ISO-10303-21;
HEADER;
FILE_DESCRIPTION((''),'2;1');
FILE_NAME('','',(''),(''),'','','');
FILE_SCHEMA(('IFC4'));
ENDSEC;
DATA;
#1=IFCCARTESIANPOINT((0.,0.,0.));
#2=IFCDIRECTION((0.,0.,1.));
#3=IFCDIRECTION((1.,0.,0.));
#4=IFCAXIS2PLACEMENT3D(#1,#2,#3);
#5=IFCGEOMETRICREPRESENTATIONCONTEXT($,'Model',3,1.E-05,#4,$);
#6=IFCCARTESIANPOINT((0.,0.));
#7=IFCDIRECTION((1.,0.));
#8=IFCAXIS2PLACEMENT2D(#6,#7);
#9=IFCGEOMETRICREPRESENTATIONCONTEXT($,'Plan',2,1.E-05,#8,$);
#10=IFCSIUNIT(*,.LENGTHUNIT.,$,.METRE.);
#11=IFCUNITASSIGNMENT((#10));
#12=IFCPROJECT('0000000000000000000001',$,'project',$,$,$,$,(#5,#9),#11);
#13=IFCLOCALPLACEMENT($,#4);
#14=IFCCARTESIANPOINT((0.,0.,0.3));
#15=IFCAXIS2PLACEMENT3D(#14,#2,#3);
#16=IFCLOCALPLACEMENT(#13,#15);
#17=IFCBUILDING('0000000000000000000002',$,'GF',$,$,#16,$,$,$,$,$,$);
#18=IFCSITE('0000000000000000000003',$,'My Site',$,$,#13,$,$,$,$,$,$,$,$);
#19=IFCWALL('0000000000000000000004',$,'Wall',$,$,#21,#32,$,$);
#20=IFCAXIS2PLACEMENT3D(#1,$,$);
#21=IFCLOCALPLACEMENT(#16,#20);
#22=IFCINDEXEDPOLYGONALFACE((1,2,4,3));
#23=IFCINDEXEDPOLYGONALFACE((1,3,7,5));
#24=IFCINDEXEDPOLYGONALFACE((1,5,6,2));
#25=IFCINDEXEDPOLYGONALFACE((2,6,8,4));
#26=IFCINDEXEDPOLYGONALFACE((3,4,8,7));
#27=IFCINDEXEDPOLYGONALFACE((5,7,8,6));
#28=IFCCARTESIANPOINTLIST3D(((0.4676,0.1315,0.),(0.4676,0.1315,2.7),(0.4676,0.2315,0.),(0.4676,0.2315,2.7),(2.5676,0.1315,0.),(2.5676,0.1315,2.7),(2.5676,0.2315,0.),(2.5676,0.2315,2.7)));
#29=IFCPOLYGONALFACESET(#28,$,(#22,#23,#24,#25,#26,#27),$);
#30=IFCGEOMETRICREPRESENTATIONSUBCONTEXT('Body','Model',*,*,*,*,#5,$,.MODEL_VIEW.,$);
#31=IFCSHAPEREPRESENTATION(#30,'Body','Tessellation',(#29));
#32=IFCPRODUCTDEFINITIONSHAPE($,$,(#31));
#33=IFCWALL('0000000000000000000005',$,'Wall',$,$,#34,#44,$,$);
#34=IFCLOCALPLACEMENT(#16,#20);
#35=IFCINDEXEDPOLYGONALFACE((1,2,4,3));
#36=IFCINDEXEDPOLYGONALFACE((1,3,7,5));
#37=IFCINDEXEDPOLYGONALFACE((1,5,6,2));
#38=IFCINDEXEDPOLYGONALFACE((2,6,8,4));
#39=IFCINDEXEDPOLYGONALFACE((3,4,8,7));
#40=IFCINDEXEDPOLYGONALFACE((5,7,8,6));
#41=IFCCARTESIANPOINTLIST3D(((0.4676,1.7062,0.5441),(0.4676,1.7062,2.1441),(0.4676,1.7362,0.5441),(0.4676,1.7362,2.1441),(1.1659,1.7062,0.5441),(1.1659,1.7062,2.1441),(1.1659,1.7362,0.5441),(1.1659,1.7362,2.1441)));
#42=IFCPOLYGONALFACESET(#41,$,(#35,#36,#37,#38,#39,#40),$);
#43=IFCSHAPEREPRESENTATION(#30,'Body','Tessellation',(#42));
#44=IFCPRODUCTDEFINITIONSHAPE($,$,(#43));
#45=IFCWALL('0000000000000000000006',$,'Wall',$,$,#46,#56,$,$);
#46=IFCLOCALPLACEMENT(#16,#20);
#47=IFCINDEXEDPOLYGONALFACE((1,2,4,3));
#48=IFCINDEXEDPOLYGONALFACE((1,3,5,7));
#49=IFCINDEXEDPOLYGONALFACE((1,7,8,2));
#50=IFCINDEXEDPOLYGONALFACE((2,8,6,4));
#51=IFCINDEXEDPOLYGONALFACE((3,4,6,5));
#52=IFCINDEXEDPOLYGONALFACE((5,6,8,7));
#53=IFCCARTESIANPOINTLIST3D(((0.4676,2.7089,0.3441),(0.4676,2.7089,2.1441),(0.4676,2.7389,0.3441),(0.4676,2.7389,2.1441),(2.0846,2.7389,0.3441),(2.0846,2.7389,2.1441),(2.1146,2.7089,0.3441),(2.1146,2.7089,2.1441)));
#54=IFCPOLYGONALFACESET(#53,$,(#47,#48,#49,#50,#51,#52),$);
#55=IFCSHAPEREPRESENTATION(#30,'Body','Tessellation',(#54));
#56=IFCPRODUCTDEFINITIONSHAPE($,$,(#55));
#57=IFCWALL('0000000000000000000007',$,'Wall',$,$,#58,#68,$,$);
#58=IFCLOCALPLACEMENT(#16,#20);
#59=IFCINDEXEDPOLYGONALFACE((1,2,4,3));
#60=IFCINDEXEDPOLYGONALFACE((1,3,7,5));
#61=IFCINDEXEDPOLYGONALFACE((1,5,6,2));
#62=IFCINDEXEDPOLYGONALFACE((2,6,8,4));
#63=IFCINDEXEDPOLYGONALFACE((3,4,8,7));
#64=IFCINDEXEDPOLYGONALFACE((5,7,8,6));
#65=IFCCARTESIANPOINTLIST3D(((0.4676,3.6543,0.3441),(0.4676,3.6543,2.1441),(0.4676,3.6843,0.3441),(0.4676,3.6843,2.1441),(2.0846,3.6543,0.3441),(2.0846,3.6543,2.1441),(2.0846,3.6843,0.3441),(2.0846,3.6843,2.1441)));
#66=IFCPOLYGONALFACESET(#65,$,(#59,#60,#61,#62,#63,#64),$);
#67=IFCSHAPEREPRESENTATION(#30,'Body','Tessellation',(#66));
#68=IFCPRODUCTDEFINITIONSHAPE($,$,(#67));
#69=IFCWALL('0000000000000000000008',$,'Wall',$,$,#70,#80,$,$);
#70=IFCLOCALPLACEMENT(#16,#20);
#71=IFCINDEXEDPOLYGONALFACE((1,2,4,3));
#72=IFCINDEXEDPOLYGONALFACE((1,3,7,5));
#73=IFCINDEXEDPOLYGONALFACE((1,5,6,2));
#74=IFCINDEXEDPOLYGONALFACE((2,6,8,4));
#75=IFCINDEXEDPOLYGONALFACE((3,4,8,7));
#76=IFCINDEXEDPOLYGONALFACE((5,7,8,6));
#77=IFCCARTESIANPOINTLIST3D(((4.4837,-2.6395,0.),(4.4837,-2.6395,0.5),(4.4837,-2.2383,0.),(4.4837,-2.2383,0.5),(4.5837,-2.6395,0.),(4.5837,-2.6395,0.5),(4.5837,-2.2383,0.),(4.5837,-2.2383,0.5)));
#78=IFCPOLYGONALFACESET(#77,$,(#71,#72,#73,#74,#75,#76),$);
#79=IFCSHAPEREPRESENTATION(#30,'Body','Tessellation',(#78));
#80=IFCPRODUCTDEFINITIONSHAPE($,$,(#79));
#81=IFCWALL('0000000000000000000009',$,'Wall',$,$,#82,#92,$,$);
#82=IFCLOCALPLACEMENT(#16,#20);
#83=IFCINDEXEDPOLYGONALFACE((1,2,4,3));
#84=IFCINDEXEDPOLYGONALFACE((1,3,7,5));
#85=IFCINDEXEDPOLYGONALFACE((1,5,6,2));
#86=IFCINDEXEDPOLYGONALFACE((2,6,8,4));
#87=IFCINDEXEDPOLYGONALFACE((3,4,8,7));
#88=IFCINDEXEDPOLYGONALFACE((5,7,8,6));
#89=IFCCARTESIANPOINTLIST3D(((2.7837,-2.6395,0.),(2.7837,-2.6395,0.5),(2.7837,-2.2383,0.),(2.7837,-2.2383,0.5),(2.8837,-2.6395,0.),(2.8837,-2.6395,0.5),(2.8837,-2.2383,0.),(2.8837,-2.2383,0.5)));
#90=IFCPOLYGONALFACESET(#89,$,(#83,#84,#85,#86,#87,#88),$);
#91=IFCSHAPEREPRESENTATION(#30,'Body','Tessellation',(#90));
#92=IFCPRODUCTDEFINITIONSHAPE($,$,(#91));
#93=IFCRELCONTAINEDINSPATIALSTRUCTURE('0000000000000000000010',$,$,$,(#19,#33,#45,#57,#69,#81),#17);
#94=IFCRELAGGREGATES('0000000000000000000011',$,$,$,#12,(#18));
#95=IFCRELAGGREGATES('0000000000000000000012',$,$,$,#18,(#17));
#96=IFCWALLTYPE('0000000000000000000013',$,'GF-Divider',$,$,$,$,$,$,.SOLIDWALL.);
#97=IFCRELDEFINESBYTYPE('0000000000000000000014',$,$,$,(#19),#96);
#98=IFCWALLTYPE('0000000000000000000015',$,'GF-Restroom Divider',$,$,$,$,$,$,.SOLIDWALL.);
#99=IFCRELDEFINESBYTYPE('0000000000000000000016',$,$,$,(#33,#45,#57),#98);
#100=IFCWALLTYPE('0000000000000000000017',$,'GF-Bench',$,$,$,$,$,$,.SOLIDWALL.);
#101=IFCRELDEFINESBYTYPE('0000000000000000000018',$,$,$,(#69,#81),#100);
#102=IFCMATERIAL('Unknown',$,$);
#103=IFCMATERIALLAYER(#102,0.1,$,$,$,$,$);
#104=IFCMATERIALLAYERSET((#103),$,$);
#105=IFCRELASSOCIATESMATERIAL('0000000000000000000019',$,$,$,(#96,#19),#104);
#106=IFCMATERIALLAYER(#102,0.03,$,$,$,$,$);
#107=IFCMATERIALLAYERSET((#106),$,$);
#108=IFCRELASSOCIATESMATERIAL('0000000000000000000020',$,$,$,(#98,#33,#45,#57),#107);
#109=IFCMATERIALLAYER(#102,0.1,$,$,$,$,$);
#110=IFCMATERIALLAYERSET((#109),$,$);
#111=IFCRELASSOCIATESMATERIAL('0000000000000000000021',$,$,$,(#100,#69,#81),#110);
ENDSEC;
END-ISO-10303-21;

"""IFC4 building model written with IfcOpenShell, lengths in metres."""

from ifc_helpers import new_model, si_unit, frame, origin_with_axes, origin_2d_with_axis, place, context, subcontext, project, spatial, line, indexed_curve, outline, extrude, material, layer, layer_set, layer_usage, type_object, element, save


model = new_model("IFC4")

# Units and contexts
model_context = context("Model", 3, precision=1e-05, world=origin_with_axes())
plan_context = context("Plan", 2, precision=1e-05, world=origin_2d_with_axis())
body_context_1 = subcontext(model_context, "Body", "Model", "MODEL_VIEW")
ifc_project = project(units=[si_unit("LENGTHUNIT", "METRE")], contexts=[model_context, plan_context])

# Site, building
site_placement = place(None, origin_with_axes())
site = spatial("IfcSite", under=ifc_project, at=site_placement, Name="My Site")
building_placement = place(site_placement, frame((0.0, 0.0, 0.3), z_axis=(0.0, 0.0, 1.0), x_axis=(1.0, 0.0, 0.0)))
building = spatial("IfcBuilding", under=site, at=building_placement, Name="GF")

# Shared definitions
ifc_material = material(Name="Unknown")

# Walls
ifc_layer_1 = layer(ifc_material, 0.1)
ifc_layer_set_1 = layer_set([ifc_layer_1])
ifc_layer_usage_1 = layer_usage(ifc_layer_set_1, "AXIS2", "POSITIVE", 0.0)
wall_type_1 = type_object("IfcWallType", Name="GF-Divider", PredefinedType="SOLIDWALL", material=ifc_layer_set_1)
wall_1_placement = place(building_placement, frame((0.4676, 0.1315, 0.0), z_axis=(0.0, 0.0, 1.0), x_axis=(1.0, 0.0, 0.0)))
element("IfcWall", 1, at=wall_1_placement, inside=building, type_object=wall_type_1, material=ifc_layer_usage_1, Name="Wall", context=body_context_1, shape_type="SweptSolid", body=[
    extrude(outline(indexed_curve([(0.0, 0.0), (0.0, 0.1), (2.0999, 0.1), (2.0999, 0.0)], segments=[line(1, 2, 3, 4, 1)])), origin_with_axes(), (0.0, 0.0, 1.0), 2.7),
])
ifc_layer_2 = layer(ifc_material, 0.03)
ifc_layer_set_2 = layer_set([ifc_layer_2])
ifc_layer_usage_2 = layer_usage(ifc_layer_set_2, "AXIS2", "POSITIVE", 0.0)
wall_type_2 = type_object("IfcWallType", Name="GF-Restroom Divider", PredefinedType="SOLIDWALL", material=ifc_layer_set_2)
wall_2_placement = place(building_placement, frame((0.4676, 1.7062, 0.5441), z_axis=(0.0, 0.0, 1.0), x_axis=(1.0, 0.0, 0.0)))
element("IfcWall", 2, at=wall_2_placement, inside=building, type_object=wall_type_2, material=ifc_layer_usage_2, Name="Wall", context=body_context_1, shape_type="SweptSolid", body=[
    extrude(outline(indexed_curve([(0.0, 0.0), (0.0, 0.03), (0.6983, 0.03), (0.6983, 0.0)], segments=[line(1, 2, 3, 4, 1)])), origin_with_axes(), (0.0, 0.0, 1.0), 1.6),
])
ifc_layer_usage_3 = layer_usage(ifc_layer_set_2, "AXIS2", "POSITIVE", 0.0)
wall_3_placement = place(building_placement, frame((0.4676, 2.7089, 0.3441), z_axis=(0.0, 0.0, 1.0), x_axis=(1.0, 0.0, 0.0)))
element("IfcWall", 3, at=wall_3_placement, inside=building, type_object=wall_type_2, material=ifc_layer_usage_3, Name="Wall", context=body_context_1, shape_type="SweptSolid", body=[
    extrude(outline(indexed_curve([(0.0, 0.0), (0.0, 0.03), (1.617, 0.03), (1.647, 0.0)], segments=[line(1, 2, 3, 4, 1)])), origin_with_axes(), (0.0, 0.0, 1.0), 1.8),
])

# Walls
ifc_layer_usage_4 = layer_usage(ifc_layer_set_2, "AXIS2", "POSITIVE", 0.0)
wall_4_placement = place(building_placement, frame((2.0846, 3.6843, 0.3441), z_axis=(0.0, 0.0, 1.0), x_axis=(-1.0, 0.0, 0.0)))
element("IfcWall", 4, at=wall_4_placement, inside=building, type_object=wall_type_2, material=ifc_layer_usage_4, Name="Wall", context=body_context_1, shape_type="SweptSolid", body=[
    extrude(outline(indexed_curve([(0.0, 0.0), (0.0, 0.03), (1.617, 0.03), (1.617, 0.0)], segments=[line(1, 2, 3, 4, 1)])), origin_with_axes(), (0.0, 0.0, 1.0), 1.8),
])
ifc_layer_3 = layer(ifc_material, 0.1)
ifc_layer_set_3 = layer_set([ifc_layer_3])
ifc_layer_usage_5 = layer_usage(ifc_layer_set_3, "AXIS2", "POSITIVE", 0.0)
wall_type_3 = type_object("IfcWallType", Name="GF-Bench", PredefinedType="SOLIDWALL", material=ifc_layer_set_3)
wall_5_placement = place(building_placement, frame((4.4837, -2.2383, 0.0), z_axis=(0.0, 0.0, 1.0), x_axis=(-0.000002, -1.0, 0.0)))
element("IfcWall", 5, at=wall_5_placement, inside=building, type_object=wall_type_3, material=ifc_layer_usage_5, Name="Wall", context=body_context_1, shape_type="SweptSolid", body=[
    extrude(outline(indexed_curve([(0.0, 0.0), (0.0, 0.1), (0.4011, 0.1), (0.4011, 0.0)], segments=[line(1, 2, 3, 4, 1)])), origin_with_axes(), (0.0, 0.0, 1.0), 0.5),
])
ifc_layer_usage_6 = layer_usage(ifc_layer_set_3, "AXIS2", "POSITIVE", 0.0)
wall_6_placement = place(building_placement, frame((2.7837, -2.2383, 0.0), z_axis=(0.0, 0.0, 1.0), x_axis=(-0.000002, -1.0, 0.0)))
element("IfcWall", 6, at=wall_6_placement, inside=building, type_object=wall_type_3, material=ifc_layer_usage_6, Name="Wall", context=body_context_1, shape_type="SweptSolid", body=[
    extrude(outline(indexed_curve([(0.0, 0.0), (0.0, 0.1), (0.4011, 0.1), (0.4011, 0.0)], segments=[line(1, 2, 3, 4, 1)])), origin_with_axes(), (0.0, 0.0, 1.0), 0.5),
])

save(model, "model.ifc")
